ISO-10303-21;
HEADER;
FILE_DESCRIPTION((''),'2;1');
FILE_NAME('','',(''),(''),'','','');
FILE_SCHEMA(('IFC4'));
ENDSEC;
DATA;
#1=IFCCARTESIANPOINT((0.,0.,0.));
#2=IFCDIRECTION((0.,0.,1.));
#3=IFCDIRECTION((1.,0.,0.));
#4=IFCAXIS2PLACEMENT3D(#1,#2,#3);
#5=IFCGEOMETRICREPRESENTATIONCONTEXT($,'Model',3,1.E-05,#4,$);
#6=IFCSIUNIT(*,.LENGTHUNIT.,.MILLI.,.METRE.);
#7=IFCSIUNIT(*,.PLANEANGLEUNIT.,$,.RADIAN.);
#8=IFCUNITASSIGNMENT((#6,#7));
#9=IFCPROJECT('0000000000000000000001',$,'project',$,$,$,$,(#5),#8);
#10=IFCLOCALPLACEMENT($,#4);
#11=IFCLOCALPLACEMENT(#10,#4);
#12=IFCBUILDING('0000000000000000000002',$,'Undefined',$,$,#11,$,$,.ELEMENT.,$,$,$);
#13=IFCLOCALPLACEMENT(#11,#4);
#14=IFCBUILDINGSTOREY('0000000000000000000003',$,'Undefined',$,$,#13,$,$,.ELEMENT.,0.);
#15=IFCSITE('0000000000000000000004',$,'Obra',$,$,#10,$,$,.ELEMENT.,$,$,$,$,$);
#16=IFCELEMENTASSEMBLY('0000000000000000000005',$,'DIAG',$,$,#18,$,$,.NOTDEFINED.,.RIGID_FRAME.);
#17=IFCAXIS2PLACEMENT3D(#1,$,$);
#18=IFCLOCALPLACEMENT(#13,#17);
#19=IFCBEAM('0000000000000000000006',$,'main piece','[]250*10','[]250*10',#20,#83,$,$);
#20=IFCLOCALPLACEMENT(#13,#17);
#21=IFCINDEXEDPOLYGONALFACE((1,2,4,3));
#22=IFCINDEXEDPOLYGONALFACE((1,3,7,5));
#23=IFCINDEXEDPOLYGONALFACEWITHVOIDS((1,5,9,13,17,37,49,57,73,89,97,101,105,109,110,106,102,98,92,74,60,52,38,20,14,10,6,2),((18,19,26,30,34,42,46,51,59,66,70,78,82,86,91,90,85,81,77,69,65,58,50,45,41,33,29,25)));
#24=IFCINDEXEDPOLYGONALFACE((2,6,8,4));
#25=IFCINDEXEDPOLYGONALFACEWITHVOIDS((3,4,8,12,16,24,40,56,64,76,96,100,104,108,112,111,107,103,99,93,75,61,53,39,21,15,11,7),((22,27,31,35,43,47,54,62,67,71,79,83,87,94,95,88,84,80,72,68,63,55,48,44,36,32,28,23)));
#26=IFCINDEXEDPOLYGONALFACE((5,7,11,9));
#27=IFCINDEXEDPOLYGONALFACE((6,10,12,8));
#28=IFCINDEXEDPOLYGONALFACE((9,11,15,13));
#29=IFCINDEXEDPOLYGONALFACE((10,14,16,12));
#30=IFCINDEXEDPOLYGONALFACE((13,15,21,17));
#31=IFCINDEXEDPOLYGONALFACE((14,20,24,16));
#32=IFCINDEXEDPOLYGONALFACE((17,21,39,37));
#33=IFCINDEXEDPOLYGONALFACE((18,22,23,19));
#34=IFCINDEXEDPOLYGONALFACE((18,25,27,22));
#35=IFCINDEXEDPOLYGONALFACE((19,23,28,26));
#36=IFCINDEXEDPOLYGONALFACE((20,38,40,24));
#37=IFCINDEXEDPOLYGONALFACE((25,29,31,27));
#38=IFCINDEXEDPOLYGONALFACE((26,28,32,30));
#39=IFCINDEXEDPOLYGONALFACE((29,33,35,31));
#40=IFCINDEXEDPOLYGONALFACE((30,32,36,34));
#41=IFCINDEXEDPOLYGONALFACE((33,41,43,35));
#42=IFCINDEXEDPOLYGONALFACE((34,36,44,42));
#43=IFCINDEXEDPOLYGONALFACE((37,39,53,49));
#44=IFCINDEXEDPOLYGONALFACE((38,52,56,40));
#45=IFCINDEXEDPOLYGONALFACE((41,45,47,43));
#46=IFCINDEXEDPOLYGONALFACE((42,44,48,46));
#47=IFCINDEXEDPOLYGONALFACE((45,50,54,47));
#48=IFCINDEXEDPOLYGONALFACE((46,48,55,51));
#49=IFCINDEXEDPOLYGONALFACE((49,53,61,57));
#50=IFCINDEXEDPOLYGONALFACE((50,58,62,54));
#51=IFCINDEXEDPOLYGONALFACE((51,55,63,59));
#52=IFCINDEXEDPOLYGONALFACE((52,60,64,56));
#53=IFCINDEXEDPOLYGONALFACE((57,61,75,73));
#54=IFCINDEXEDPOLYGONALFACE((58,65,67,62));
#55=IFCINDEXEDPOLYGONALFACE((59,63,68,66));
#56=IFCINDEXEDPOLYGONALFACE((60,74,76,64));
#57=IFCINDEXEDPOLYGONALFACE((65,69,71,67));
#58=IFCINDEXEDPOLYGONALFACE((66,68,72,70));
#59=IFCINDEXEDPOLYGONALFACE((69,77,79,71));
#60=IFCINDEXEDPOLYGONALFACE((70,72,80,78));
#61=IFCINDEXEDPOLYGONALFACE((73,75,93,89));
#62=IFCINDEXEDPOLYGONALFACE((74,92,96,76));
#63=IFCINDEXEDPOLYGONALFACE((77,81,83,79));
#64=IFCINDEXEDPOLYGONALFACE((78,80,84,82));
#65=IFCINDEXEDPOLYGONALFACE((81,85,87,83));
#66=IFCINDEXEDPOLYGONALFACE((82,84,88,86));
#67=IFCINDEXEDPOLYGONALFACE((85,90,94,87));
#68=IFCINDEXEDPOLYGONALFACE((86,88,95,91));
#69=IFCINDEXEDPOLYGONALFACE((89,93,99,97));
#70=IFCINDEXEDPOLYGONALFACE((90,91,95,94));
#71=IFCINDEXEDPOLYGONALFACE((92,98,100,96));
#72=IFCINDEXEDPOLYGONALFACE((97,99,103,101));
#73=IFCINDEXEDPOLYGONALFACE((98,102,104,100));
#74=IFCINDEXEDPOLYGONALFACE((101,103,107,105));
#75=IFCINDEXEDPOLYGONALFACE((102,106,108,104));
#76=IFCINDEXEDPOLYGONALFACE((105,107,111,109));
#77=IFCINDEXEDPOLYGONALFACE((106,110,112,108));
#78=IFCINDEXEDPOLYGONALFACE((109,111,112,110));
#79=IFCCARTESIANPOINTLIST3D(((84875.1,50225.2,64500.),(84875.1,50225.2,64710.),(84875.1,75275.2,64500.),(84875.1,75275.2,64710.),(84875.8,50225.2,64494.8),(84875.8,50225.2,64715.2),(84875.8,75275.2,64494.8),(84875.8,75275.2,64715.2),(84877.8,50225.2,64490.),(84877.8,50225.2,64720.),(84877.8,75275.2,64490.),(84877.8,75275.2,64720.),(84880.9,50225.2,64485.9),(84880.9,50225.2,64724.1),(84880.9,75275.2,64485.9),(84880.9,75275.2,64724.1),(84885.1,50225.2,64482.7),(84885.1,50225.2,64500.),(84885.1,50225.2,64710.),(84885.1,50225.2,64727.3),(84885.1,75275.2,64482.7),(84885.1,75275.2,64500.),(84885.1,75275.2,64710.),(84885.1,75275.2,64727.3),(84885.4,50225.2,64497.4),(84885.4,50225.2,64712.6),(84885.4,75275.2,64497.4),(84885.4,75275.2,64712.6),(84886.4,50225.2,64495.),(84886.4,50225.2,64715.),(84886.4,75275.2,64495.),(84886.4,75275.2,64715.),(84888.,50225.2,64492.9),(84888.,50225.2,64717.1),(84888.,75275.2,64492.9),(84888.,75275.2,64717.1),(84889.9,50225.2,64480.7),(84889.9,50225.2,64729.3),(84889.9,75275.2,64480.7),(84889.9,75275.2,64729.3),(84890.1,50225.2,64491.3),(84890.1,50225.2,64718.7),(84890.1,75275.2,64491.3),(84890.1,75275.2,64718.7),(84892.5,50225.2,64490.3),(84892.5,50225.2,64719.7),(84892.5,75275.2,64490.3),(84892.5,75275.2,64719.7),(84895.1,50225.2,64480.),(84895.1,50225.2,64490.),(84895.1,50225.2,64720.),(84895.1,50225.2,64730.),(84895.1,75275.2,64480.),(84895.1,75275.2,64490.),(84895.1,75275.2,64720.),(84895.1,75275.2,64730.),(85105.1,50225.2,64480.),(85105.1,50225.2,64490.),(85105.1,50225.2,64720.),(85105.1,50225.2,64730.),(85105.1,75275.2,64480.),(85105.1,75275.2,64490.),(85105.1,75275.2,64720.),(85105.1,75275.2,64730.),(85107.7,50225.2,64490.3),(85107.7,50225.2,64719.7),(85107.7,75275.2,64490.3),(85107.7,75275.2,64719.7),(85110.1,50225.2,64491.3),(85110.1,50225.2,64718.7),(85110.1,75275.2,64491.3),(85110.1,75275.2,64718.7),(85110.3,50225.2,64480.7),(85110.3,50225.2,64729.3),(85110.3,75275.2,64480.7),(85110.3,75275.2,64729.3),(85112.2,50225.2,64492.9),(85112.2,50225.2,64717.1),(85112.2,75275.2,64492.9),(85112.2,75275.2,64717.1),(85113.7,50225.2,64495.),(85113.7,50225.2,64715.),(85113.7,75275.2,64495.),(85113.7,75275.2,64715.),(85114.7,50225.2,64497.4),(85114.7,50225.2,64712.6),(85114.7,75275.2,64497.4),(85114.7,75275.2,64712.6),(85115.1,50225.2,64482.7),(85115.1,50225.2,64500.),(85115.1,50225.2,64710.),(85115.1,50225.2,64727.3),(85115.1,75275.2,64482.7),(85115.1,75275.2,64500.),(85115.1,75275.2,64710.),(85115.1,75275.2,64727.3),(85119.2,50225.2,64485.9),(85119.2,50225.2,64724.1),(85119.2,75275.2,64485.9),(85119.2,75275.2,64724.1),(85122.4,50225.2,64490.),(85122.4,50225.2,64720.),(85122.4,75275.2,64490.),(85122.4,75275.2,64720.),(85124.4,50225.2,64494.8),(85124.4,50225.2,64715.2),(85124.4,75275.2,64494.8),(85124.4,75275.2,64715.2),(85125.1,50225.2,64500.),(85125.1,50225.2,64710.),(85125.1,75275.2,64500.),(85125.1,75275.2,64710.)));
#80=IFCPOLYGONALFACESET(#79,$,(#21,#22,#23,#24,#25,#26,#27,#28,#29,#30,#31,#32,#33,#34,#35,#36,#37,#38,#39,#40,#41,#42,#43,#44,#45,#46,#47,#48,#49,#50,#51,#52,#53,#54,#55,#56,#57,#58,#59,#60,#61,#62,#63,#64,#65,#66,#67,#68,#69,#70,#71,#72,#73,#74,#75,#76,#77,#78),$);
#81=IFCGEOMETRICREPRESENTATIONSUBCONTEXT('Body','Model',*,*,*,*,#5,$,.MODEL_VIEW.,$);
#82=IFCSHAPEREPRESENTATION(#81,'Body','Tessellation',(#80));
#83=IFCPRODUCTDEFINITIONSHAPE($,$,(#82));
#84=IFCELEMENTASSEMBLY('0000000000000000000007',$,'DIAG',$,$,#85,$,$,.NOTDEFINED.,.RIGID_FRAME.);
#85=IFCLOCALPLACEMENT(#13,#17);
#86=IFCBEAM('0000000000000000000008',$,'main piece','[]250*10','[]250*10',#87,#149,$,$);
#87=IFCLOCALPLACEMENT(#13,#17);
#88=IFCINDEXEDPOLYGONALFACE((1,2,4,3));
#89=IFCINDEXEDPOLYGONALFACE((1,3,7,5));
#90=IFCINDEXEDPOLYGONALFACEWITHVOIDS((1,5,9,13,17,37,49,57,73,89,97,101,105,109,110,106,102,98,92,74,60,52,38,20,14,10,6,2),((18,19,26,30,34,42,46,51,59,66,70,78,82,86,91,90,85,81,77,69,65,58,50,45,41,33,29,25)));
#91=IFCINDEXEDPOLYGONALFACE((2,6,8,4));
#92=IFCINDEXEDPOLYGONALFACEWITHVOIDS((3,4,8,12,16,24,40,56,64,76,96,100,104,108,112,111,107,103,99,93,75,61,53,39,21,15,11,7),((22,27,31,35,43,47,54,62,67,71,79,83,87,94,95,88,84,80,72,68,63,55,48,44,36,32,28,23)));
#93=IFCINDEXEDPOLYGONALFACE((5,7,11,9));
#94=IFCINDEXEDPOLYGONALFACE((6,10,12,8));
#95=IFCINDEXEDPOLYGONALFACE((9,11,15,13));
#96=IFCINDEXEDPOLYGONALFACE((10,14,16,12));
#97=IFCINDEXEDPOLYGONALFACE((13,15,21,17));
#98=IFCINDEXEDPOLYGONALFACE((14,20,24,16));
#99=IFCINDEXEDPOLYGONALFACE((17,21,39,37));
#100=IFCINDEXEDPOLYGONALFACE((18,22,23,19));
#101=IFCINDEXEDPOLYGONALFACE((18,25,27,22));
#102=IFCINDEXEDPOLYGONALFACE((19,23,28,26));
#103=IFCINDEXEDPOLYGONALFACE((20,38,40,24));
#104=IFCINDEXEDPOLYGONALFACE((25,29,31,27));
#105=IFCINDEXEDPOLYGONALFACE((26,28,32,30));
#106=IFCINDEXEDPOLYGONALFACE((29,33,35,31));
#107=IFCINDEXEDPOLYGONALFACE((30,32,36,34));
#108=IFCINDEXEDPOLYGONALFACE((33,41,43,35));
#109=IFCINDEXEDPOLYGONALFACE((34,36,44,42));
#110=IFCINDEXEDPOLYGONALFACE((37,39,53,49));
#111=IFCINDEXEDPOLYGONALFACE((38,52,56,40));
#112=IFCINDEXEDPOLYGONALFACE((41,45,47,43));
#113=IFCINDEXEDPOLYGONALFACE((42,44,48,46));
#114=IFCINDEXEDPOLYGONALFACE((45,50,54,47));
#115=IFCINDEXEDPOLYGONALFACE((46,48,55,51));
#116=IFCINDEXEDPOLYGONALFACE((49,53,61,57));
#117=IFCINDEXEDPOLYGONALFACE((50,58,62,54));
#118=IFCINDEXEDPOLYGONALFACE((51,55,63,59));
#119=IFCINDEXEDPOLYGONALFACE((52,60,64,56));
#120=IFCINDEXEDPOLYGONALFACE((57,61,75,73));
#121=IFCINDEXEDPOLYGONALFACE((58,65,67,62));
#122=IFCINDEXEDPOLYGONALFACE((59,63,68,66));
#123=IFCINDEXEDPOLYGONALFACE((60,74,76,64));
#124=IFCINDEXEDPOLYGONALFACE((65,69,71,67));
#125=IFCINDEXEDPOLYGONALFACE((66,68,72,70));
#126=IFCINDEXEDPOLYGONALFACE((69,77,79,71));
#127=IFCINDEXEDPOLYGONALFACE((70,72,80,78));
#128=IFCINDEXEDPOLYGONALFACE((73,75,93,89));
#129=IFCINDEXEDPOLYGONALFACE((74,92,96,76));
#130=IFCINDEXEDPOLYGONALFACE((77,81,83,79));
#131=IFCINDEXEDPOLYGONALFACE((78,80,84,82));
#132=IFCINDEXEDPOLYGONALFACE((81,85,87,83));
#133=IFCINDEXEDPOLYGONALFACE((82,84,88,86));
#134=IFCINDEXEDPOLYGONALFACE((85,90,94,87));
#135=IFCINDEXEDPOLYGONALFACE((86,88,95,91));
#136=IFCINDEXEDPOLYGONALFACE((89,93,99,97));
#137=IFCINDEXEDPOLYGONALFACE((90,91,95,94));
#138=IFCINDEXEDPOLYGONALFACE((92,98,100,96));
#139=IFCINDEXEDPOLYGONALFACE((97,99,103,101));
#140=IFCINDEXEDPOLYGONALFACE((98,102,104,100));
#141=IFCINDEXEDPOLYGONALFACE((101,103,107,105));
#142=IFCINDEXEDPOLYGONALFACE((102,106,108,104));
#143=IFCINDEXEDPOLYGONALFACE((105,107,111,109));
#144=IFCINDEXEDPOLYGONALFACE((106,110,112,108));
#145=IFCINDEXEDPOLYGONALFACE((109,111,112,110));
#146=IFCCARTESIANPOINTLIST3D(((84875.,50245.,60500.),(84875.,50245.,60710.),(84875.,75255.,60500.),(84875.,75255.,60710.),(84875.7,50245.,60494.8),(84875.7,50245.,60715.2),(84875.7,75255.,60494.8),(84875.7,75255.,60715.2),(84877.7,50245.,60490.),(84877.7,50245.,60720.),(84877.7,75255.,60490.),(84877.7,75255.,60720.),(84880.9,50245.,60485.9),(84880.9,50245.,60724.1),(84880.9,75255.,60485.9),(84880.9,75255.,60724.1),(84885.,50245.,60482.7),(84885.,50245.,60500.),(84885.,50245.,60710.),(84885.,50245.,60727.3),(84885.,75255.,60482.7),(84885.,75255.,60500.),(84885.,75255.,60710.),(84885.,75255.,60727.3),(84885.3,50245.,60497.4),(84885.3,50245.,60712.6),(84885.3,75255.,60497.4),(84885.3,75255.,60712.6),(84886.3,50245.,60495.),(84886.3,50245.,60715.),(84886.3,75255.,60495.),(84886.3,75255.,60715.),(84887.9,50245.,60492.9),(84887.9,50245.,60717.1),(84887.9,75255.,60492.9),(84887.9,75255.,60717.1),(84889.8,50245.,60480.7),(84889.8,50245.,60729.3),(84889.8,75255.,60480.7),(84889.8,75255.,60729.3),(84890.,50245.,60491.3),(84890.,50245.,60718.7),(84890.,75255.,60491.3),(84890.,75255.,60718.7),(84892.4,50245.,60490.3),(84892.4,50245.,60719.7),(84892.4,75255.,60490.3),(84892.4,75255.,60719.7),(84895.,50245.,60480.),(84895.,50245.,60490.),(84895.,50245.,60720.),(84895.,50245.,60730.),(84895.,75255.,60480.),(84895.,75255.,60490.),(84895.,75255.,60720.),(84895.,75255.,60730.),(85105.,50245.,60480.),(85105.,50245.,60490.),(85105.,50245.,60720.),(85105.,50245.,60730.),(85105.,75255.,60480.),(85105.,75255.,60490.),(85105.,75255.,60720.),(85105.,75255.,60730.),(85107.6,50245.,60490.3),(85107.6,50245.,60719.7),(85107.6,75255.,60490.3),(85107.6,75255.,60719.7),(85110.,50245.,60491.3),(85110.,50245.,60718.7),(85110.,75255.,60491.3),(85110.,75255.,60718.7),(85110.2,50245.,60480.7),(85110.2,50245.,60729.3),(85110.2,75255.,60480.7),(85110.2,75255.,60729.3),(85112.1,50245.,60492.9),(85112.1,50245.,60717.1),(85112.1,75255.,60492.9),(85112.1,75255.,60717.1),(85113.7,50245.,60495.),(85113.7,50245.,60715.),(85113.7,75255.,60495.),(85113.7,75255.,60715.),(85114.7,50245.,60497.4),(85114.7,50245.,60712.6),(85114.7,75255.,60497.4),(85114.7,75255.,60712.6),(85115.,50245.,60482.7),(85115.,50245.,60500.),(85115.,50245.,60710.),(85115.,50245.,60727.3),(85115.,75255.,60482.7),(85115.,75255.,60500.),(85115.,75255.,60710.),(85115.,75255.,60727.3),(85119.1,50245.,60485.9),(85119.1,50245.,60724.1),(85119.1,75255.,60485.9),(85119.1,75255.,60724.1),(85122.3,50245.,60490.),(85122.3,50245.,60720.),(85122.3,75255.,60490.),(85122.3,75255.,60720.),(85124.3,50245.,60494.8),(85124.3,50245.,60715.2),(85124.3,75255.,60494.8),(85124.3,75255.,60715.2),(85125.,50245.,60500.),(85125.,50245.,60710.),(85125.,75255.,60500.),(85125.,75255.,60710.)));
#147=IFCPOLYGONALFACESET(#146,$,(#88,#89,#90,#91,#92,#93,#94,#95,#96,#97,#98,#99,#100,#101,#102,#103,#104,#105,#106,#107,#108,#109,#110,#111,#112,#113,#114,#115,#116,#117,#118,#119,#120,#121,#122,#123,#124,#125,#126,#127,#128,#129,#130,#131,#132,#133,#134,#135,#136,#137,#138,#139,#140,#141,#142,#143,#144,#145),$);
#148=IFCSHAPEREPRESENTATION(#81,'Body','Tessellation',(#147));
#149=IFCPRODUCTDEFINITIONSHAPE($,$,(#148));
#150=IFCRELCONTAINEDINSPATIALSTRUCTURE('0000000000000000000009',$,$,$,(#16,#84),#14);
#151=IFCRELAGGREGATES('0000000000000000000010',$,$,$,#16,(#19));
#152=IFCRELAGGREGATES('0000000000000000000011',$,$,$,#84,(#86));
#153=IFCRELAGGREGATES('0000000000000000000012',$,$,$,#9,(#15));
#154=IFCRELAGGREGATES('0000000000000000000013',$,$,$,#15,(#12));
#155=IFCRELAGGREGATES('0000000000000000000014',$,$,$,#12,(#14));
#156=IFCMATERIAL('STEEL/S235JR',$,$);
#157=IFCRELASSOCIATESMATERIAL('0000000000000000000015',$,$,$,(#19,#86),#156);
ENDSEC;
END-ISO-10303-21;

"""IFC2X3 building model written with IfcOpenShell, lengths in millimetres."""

from ifc_helpers import new_model, si_unit, frame, origin_with_axes, origin_2d_with_axis, place, context, subcontext, project, spatial, hollow_rectangle, extrude, material, element, aggregate, save


model = new_model("IFC2X3")

# Units and contexts
model_context = context("Model", 3, precision=1e-05, world=origin_with_axes())
body_context = subcontext(model_context, "Body", "Model", "MODEL_VIEW")
ifc_project = project(units=[si_unit("LENGTHUNIT", "METRE", prefix="MILLI"), si_unit("PLANEANGLEUNIT", "RADIAN")], contexts=[model_context])

# Site, building, storey
site_placement = place(None, origin_with_axes())
site = spatial("IfcSite", under=ifc_project, at=site_placement, Name="Obra", CompositionType="ELEMENT")
building_placement = place(site_placement, origin_with_axes())
building = spatial("IfcBuilding", under=site, at=building_placement, Name="Undefined", CompositionType="ELEMENT")
storey_placement = place(building_placement, origin_with_axes())
storey = spatial("IfcBuildingStorey", under=building, at=storey_placement, Name="Undefined", CompositionType="ELEMENT", Elevation=0.0)

# Shared definitions
ifc_material = material(Name="STEEL/S235JR")

# Element assemblies, beams
assembly_1_placement = place(storey_placement, origin_with_axes())
assembly_1 = element("IfcElementAssembly", 1, at=assembly_1_placement, inside=storey, Name="DIAG", AssemblyPlace="NOTDEFINED", PredefinedType="RIGID_FRAME")
beam_1_placement = place(assembly_1_placement, frame((85000.1, 50225.2, 64605.0), z_axis=(0.0, 0.0, 1.0), x_axis=(0.0, 1.0, 0.0)))
beam_1 = element("IfcBeam", 2, at=beam_1_placement, material=ifc_material, Name="main piece", Description="[]250*10", ObjectType="[]250*10", context=body_context, shape_type="SweptSolid", body=[
    extrude(hollow_rectangle(XDim=250.0, YDim=250.0, WallThickness=10.0, InnerFilletRadius=10.0, OuterFilletRadius=20.0, at=origin_2d_with_axis()), frame((25050.0, 0.0, 0.0), z_axis=(-1.0, 0.0, 0.0), x_axis=(0.0, -1.0, 0.0)), (0.0, 0.0, 1.0), 25050.0),
])
aggregate(assembly_1, [beam_1])
assembly_2_placement = place(storey_placement, origin_with_axes())
assembly_2 = element("IfcElementAssembly", 3, at=assembly_2_placement, inside=storey, Name="DIAG", AssemblyPlace="NOTDEFINED", PredefinedType="RIGID_FRAME")
beam_2_placement = place(assembly_2_placement, frame((85000.0, 50245.0, 60605.0), z_axis=(0.0, 0.0, 1.0), x_axis=(0.0, 1.0, 0.0)))
beam_2 = element("IfcBeam", 4, at=beam_2_placement, material=ifc_material, Name="main piece", Description="[]250*10", ObjectType="[]250*10", context=body_context, shape_type="SweptSolid", body=[
    extrude(hollow_rectangle(XDim=250.0, YDim=250.0, WallThickness=10.0, InnerFilletRadius=10.0, OuterFilletRadius=20.0, at=origin_2d_with_axis()), frame((25010.0, 0.0, 0.0), z_axis=(-1.0, 0.0, 0.0), x_axis=(0.0, -1.0, 0.0)), (0.0, 0.0, 1.0), 25010.0),
])
aggregate(assembly_2, [beam_2])

save(model, "model.ifc")
